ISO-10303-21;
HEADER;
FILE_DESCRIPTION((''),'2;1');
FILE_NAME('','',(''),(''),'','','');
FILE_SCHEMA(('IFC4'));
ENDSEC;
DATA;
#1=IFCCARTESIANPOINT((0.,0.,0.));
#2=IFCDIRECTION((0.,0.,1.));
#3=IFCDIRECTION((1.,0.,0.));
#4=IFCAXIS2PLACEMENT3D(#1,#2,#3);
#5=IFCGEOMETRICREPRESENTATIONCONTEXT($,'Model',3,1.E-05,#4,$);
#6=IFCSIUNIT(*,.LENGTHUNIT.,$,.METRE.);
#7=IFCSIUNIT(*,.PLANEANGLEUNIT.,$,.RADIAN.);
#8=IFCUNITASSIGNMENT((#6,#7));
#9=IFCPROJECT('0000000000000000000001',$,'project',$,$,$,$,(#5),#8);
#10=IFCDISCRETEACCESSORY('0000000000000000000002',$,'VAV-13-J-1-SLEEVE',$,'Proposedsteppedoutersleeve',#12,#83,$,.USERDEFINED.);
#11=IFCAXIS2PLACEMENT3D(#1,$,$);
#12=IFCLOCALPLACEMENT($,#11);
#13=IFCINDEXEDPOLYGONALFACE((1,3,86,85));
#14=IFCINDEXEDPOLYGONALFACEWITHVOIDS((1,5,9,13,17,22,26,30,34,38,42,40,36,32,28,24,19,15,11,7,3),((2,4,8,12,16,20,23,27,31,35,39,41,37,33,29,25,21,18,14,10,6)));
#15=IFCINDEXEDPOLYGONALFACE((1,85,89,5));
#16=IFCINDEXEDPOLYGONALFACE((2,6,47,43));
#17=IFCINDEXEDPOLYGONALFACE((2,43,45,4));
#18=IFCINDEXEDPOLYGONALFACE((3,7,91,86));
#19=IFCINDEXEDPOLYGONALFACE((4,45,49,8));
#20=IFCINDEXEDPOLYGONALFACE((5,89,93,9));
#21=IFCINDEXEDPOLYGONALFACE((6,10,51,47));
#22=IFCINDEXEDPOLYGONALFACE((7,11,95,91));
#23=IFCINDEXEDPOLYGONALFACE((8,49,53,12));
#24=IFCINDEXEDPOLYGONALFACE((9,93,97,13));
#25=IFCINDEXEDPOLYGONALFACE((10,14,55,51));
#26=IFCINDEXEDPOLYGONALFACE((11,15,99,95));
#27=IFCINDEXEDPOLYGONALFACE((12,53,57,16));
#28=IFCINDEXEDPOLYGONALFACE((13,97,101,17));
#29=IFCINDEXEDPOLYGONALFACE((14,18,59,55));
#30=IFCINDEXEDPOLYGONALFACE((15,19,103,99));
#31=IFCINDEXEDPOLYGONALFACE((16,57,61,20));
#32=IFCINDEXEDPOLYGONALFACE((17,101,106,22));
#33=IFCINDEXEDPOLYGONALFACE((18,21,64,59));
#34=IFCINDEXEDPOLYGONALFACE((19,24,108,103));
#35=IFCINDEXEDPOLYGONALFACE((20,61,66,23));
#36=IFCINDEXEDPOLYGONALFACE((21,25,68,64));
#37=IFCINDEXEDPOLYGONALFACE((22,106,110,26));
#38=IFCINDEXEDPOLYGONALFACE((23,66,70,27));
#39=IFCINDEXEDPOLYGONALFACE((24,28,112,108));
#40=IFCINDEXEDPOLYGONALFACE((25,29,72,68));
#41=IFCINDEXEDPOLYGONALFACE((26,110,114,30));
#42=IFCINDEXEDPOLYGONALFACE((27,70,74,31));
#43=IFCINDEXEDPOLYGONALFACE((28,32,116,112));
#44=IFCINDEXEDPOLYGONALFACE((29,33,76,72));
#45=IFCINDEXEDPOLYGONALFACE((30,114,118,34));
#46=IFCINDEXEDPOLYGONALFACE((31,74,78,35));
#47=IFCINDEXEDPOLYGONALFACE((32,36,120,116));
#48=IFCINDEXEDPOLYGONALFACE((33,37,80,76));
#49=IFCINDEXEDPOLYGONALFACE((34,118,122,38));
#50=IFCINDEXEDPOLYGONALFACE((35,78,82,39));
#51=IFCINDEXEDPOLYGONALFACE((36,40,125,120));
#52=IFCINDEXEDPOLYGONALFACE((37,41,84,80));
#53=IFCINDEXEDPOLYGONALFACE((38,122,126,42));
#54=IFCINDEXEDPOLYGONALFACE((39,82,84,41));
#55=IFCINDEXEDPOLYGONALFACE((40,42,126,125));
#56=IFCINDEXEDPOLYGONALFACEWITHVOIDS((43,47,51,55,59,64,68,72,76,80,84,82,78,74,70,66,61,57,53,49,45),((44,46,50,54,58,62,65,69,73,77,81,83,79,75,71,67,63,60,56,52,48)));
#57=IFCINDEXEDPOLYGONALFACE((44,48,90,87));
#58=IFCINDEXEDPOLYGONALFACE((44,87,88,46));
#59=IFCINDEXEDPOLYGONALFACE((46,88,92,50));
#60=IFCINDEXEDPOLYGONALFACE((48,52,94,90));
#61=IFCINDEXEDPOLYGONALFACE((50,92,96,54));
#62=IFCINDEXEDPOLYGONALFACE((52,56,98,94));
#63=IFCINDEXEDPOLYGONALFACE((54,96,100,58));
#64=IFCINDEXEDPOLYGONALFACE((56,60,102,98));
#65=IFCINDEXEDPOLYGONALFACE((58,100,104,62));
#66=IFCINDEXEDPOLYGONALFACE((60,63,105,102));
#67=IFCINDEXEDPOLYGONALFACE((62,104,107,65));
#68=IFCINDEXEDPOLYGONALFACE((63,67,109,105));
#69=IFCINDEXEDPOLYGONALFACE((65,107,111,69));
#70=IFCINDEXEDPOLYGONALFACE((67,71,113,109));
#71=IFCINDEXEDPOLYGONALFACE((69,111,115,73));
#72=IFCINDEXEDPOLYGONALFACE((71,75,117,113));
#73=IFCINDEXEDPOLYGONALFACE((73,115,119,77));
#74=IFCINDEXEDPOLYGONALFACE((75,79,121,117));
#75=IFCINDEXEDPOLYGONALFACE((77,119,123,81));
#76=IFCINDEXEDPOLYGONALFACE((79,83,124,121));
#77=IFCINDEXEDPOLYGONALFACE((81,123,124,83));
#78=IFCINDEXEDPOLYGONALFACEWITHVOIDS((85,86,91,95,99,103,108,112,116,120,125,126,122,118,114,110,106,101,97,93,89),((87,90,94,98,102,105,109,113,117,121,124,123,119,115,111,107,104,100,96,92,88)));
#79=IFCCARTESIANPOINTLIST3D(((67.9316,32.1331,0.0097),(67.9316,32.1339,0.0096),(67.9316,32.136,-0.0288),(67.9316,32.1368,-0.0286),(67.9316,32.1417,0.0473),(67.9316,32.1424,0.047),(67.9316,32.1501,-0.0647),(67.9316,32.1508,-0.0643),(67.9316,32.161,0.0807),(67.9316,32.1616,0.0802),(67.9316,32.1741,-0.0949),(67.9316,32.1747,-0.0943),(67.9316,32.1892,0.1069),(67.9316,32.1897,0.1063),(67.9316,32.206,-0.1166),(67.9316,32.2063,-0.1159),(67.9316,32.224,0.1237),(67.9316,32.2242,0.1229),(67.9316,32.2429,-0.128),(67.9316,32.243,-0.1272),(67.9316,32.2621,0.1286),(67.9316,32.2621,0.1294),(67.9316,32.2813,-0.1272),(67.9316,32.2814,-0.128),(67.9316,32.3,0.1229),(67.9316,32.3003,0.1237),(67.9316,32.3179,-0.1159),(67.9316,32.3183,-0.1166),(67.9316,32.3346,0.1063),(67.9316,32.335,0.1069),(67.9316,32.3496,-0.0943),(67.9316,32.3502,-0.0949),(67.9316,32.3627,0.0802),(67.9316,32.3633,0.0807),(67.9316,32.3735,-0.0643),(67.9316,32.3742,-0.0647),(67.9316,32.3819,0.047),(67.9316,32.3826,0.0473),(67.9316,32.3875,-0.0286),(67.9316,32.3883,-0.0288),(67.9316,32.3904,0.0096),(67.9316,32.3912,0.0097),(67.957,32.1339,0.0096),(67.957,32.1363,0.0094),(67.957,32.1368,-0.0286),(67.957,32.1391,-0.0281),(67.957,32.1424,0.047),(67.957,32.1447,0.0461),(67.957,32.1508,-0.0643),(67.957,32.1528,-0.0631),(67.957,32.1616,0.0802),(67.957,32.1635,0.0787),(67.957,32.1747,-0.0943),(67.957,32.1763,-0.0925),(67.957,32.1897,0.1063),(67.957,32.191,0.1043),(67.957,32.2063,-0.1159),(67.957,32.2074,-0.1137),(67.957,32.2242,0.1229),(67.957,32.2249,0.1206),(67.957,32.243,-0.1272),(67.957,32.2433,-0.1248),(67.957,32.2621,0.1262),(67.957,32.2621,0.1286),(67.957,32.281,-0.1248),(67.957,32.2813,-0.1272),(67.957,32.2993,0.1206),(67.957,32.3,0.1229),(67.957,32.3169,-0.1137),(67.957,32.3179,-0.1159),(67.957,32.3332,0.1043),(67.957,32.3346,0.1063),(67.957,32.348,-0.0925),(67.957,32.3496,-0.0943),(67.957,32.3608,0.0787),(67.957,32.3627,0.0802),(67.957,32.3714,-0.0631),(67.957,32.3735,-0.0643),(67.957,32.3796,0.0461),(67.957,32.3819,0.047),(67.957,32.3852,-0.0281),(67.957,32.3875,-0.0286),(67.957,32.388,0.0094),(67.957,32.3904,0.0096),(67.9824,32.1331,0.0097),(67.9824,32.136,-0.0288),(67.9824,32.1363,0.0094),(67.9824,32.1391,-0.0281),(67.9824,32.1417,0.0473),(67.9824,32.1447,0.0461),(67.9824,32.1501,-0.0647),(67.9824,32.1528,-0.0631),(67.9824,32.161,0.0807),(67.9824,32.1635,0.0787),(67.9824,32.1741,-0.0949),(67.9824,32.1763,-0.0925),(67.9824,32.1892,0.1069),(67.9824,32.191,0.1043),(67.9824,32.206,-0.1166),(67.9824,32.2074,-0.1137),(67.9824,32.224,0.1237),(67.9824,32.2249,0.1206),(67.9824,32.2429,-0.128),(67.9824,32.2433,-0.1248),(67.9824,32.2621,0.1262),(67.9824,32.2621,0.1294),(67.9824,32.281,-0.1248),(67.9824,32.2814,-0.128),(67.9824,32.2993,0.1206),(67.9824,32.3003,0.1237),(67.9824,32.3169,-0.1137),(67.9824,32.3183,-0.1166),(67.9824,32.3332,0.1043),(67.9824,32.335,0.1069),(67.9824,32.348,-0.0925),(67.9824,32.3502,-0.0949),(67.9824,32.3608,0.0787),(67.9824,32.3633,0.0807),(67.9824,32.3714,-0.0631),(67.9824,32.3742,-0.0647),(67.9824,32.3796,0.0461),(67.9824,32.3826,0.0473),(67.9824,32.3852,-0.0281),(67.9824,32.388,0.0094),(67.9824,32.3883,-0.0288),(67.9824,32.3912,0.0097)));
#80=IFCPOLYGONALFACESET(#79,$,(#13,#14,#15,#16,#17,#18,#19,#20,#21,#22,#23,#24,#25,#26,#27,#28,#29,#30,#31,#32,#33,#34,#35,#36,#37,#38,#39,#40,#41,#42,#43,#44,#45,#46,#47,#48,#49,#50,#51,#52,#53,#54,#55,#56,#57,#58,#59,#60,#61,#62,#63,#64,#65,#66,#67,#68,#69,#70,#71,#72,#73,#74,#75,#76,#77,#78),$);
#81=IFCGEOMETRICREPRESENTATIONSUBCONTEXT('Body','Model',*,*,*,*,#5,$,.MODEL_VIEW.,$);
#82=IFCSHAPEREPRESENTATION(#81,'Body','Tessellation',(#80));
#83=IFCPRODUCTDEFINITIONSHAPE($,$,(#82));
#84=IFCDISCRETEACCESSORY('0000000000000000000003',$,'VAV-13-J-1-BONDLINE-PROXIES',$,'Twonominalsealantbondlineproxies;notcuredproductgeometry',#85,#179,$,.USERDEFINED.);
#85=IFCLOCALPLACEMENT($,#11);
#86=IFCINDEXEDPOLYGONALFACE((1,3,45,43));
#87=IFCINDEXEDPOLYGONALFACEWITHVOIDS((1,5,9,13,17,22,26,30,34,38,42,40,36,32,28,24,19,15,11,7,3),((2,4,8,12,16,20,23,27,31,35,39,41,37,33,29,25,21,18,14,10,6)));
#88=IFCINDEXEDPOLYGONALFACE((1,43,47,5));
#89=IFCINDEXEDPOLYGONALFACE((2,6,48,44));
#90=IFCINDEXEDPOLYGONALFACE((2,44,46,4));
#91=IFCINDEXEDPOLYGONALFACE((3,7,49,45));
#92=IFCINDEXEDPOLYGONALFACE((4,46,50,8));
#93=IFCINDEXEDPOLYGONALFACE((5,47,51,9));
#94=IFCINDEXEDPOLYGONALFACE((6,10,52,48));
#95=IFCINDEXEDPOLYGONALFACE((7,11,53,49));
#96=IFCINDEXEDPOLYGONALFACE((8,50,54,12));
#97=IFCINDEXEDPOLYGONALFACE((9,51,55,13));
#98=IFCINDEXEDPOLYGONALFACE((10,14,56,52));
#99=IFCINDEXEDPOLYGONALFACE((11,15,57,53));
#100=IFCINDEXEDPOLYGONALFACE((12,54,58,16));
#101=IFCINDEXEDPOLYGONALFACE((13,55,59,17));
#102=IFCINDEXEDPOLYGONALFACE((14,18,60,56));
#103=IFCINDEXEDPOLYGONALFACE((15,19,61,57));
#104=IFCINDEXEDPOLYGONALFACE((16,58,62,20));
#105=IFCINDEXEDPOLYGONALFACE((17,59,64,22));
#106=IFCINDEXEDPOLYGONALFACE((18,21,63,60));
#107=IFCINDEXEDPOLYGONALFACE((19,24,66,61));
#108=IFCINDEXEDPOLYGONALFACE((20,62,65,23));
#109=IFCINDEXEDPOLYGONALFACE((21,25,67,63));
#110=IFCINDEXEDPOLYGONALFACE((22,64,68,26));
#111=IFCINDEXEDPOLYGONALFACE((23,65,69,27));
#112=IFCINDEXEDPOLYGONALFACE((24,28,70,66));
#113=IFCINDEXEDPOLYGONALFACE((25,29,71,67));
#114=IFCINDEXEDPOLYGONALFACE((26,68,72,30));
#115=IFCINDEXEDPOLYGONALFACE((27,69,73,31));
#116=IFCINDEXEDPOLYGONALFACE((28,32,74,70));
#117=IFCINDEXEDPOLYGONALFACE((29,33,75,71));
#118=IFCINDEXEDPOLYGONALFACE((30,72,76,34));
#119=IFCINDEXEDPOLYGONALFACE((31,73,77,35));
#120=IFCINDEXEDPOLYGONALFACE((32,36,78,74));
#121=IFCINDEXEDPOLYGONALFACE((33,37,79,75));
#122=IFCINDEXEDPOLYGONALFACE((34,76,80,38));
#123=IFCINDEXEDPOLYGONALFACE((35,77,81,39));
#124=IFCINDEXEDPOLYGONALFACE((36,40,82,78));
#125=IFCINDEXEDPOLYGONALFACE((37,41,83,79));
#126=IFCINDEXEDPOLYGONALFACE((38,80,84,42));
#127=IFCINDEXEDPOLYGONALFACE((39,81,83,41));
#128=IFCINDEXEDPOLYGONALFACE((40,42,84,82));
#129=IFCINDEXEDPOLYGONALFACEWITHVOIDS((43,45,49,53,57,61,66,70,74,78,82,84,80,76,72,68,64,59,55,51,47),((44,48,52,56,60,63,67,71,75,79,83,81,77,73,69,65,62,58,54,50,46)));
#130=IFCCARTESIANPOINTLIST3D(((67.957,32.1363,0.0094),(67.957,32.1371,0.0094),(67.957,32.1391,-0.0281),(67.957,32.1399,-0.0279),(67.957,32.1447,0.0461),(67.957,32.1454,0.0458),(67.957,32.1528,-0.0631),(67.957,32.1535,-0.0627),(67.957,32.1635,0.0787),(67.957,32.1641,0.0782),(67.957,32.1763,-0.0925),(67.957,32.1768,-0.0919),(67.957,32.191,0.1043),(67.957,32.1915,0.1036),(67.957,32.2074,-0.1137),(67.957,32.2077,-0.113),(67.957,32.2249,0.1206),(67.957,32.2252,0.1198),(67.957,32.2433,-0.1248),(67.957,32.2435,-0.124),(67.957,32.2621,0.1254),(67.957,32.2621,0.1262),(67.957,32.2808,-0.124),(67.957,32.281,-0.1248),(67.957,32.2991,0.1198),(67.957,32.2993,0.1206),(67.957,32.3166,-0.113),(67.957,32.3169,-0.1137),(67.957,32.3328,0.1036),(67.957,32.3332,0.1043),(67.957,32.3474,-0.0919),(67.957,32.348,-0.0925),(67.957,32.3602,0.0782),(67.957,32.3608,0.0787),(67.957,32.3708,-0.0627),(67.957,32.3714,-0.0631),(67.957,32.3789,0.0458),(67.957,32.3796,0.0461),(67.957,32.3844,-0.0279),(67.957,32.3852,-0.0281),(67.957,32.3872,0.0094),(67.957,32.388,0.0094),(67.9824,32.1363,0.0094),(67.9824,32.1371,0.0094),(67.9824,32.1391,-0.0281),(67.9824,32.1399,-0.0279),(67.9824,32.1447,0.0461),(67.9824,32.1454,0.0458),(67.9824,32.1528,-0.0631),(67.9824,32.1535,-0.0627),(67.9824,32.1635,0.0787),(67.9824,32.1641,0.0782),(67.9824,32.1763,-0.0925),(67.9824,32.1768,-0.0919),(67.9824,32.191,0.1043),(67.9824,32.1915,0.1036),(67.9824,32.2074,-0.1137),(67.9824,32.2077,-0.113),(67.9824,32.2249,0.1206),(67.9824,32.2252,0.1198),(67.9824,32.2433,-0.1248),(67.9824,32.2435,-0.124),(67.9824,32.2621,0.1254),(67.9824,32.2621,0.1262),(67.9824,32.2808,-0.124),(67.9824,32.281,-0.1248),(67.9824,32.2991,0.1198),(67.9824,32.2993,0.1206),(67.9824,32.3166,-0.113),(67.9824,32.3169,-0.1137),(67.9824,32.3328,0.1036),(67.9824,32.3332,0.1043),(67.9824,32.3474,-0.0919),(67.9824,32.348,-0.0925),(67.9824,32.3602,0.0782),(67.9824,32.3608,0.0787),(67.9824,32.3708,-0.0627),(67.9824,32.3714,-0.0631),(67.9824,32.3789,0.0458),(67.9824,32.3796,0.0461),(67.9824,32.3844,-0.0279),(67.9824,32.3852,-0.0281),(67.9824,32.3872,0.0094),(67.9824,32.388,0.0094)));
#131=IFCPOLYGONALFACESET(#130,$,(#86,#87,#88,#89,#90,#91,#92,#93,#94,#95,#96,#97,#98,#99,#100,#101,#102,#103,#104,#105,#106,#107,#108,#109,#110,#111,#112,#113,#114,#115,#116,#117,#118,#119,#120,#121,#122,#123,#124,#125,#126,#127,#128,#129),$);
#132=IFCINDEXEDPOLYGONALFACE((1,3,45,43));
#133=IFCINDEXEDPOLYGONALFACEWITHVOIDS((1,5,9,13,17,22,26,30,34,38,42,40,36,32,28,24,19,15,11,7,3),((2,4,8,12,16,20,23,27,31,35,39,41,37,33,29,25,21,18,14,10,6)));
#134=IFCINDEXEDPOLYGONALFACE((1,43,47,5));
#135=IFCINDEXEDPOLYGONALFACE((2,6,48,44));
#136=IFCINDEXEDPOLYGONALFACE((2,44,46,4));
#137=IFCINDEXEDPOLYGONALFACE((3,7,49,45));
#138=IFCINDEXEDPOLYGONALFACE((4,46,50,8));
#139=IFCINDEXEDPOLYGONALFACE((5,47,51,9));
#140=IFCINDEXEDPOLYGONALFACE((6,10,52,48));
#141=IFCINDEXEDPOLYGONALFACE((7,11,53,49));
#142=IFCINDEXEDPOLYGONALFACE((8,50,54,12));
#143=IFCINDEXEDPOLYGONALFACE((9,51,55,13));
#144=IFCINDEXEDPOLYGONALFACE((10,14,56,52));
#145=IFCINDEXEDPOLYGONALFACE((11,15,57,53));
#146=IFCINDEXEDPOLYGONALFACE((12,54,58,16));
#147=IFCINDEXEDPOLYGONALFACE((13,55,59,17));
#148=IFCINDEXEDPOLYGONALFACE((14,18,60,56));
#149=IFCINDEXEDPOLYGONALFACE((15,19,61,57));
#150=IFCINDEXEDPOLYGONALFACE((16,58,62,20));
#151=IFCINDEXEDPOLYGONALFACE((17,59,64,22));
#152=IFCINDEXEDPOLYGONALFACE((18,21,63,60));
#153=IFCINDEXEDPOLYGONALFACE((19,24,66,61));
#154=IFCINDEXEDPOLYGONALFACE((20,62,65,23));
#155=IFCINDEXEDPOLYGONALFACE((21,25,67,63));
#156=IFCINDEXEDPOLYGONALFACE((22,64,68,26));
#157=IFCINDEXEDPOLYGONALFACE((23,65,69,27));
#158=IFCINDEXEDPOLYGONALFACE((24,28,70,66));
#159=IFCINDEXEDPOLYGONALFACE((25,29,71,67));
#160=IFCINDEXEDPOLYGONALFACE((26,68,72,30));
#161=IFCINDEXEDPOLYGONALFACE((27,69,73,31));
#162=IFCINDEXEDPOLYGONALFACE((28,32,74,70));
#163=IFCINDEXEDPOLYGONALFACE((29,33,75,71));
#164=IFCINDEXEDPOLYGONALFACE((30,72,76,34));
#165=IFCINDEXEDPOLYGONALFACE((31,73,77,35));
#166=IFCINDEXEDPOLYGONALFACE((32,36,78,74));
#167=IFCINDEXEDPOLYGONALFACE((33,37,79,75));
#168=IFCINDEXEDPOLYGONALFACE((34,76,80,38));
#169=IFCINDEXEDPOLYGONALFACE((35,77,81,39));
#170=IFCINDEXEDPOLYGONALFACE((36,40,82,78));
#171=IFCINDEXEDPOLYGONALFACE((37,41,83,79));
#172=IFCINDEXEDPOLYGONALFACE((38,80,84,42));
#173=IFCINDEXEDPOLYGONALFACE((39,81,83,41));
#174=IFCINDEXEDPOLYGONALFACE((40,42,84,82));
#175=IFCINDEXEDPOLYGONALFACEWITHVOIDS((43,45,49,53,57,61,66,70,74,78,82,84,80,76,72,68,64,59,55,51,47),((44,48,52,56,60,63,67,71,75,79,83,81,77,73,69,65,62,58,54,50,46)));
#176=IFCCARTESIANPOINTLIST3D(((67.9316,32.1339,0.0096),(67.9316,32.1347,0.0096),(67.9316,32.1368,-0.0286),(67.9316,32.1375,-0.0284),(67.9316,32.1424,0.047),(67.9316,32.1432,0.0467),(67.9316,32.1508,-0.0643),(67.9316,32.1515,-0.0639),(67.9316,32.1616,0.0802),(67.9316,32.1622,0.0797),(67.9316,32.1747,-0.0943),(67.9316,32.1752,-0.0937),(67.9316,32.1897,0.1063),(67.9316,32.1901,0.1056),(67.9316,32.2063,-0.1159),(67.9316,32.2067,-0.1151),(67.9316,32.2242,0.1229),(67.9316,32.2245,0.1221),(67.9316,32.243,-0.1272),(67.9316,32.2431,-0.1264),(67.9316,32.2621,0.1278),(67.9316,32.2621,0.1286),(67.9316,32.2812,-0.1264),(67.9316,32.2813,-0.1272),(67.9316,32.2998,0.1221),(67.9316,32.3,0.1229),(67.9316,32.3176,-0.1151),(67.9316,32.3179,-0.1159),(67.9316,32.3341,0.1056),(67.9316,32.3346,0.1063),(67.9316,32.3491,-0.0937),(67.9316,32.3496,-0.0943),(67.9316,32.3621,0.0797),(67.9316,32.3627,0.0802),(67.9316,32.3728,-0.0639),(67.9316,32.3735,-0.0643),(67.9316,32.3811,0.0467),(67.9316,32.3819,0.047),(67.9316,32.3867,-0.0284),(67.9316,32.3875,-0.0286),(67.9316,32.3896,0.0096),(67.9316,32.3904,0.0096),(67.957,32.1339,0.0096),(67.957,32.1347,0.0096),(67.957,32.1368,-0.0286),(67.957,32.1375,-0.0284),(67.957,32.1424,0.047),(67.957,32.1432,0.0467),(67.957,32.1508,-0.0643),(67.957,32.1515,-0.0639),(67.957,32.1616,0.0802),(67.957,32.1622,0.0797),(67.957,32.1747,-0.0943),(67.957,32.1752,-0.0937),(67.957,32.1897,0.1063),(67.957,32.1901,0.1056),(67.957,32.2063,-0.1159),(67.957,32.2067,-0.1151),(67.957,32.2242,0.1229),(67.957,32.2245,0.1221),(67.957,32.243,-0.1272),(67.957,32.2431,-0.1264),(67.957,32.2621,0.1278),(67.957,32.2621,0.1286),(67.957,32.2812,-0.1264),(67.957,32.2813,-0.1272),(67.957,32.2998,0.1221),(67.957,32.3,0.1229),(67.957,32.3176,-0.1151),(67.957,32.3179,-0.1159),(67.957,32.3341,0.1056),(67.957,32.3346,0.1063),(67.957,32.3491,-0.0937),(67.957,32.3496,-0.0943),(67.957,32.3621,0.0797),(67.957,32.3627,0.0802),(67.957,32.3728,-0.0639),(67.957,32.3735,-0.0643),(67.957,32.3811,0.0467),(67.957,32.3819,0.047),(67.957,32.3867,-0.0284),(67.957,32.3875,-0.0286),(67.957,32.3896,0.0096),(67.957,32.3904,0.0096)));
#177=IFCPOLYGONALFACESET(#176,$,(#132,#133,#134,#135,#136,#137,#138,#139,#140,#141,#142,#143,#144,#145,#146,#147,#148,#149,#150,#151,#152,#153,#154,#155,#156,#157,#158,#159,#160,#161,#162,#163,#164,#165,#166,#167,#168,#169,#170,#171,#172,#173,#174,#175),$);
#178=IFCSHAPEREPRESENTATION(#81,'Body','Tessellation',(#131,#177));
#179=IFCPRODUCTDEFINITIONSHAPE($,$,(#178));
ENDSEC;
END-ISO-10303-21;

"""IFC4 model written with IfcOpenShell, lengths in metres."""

from ifc_helpers import new_model, entity, si_unit, frame, origin_with_axes, place, context, subcontext, project, element, save


model = new_model("IFC4")

# Units and contexts
model_context = context("Model", 3, precision=1e-05, world=origin_with_axes())
body_context = subcontext(model_context, "Body", "Model", "MODEL_VIEW")
ifc_project = project(units=[si_unit("LENGTHUNIT", "METRE"), si_unit("PLANEANGLEUNIT", "RADIAN")], contexts=[model_context])

# Discrete accessories
discrete_accessory_1_placement = place(None, frame((67.957, 32.2621, 0.0), z_axis=(0.0, -1.0, 0.0), x_axis=(0.0, 0.0, 1.0)))
element("IfcDiscreteAccessory", 1, at=discrete_accessory_1_placement, Name="VAV-13-J-1-SLEEVE", ObjectType="Proposedsteppedoutersleeve", PredefinedType="USERDEFINED", context=body_context, shape_type="SweptSolid", body=[
    entity("IfcRevolvedAreaSolid", entity("IfcArbitraryClosedProfileDef", "AREA", None, entity("IfcPolyline", [entity("IfcCartesianPoint", [0.1262, -0.0254]), entity("IfcCartesianPoint", [0.1294, -0.0254]), entity("IfcCartesianPoint", [0.1294, 0.0254]), entity("IfcCartesianPoint", [0.1286, 0.0254]), entity("IfcCartesianPoint", [0.1286, 0.0]), entity("IfcCartesianPoint", [0.1262, 0.0]), entity("IfcCartesianPoint", [0.1262, -0.0254])])), entity("IfcAxis2Placement3D", entity("IfcCartesianPoint", [0.0, 0.0, 0.0])), entity("IfcAxis1Placement", entity("IfcCartesianPoint", [0.0, 0.0, 0.0]), entity("IfcDirection", [0.0, 1.0, 0.0])), 6.283185),
])
discrete_accessory_2_placement = place(None, frame((67.957, 32.2621, 0.0), z_axis=(0.0, -1.0, 0.0), x_axis=(0.0, 0.0, 1.0)))
element("IfcDiscreteAccessory", 2, at=discrete_accessory_2_placement, Name="VAV-13-J-1-BONDLINE-PROXIES", ObjectType="Twonominalsealantbondlineproxies;notcuredproductgeometry", PredefinedType="USERDEFINED", context=body_context, shape_type="SweptSolid", body=[
    entity("IfcRevolvedAreaSolid", entity("IfcArbitraryClosedProfileDef", "AREA", None, entity("IfcPolyline", [entity("IfcCartesianPoint", [0.1254, -0.0254]), entity("IfcCartesianPoint", [0.1262, -0.0254]), entity("IfcCartesianPoint", [0.1262, 0.0]), entity("IfcCartesianPoint", [0.1254, 0.0]), entity("IfcCartesianPoint", [0.1254, -0.0254])])), entity("IfcAxis2Placement3D", entity("IfcCartesianPoint", [0.0, 0.0, 0.0])), entity("IfcAxis1Placement", entity("IfcCartesianPoint", [0.0, 0.0, 0.0]), entity("IfcDirection", [0.0, 1.0, 0.0])), 6.283185),
    entity("IfcRevolvedAreaSolid", entity("IfcArbitraryClosedProfileDef", "AREA", None, entity("IfcPolyline", [entity("IfcCartesianPoint", [0.1278, 0.0]), entity("IfcCartesianPoint", [0.1286, 0.0]), entity("IfcCartesianPoint", [0.1286, 0.0254]), entity("IfcCartesianPoint", [0.1278, 0.0254]), entity("IfcCartesianPoint", [0.1278, 0.0])])), entity("IfcAxis2Placement3D", entity("IfcCartesianPoint", [0.0, 0.0, 0.0])), entity("IfcAxis1Placement", entity("IfcCartesianPoint", [0.0, 0.0, 0.0]), entity("IfcDirection", [0.0, 1.0, 0.0])), 6.283185),
])

save(model, "model.ifc")
